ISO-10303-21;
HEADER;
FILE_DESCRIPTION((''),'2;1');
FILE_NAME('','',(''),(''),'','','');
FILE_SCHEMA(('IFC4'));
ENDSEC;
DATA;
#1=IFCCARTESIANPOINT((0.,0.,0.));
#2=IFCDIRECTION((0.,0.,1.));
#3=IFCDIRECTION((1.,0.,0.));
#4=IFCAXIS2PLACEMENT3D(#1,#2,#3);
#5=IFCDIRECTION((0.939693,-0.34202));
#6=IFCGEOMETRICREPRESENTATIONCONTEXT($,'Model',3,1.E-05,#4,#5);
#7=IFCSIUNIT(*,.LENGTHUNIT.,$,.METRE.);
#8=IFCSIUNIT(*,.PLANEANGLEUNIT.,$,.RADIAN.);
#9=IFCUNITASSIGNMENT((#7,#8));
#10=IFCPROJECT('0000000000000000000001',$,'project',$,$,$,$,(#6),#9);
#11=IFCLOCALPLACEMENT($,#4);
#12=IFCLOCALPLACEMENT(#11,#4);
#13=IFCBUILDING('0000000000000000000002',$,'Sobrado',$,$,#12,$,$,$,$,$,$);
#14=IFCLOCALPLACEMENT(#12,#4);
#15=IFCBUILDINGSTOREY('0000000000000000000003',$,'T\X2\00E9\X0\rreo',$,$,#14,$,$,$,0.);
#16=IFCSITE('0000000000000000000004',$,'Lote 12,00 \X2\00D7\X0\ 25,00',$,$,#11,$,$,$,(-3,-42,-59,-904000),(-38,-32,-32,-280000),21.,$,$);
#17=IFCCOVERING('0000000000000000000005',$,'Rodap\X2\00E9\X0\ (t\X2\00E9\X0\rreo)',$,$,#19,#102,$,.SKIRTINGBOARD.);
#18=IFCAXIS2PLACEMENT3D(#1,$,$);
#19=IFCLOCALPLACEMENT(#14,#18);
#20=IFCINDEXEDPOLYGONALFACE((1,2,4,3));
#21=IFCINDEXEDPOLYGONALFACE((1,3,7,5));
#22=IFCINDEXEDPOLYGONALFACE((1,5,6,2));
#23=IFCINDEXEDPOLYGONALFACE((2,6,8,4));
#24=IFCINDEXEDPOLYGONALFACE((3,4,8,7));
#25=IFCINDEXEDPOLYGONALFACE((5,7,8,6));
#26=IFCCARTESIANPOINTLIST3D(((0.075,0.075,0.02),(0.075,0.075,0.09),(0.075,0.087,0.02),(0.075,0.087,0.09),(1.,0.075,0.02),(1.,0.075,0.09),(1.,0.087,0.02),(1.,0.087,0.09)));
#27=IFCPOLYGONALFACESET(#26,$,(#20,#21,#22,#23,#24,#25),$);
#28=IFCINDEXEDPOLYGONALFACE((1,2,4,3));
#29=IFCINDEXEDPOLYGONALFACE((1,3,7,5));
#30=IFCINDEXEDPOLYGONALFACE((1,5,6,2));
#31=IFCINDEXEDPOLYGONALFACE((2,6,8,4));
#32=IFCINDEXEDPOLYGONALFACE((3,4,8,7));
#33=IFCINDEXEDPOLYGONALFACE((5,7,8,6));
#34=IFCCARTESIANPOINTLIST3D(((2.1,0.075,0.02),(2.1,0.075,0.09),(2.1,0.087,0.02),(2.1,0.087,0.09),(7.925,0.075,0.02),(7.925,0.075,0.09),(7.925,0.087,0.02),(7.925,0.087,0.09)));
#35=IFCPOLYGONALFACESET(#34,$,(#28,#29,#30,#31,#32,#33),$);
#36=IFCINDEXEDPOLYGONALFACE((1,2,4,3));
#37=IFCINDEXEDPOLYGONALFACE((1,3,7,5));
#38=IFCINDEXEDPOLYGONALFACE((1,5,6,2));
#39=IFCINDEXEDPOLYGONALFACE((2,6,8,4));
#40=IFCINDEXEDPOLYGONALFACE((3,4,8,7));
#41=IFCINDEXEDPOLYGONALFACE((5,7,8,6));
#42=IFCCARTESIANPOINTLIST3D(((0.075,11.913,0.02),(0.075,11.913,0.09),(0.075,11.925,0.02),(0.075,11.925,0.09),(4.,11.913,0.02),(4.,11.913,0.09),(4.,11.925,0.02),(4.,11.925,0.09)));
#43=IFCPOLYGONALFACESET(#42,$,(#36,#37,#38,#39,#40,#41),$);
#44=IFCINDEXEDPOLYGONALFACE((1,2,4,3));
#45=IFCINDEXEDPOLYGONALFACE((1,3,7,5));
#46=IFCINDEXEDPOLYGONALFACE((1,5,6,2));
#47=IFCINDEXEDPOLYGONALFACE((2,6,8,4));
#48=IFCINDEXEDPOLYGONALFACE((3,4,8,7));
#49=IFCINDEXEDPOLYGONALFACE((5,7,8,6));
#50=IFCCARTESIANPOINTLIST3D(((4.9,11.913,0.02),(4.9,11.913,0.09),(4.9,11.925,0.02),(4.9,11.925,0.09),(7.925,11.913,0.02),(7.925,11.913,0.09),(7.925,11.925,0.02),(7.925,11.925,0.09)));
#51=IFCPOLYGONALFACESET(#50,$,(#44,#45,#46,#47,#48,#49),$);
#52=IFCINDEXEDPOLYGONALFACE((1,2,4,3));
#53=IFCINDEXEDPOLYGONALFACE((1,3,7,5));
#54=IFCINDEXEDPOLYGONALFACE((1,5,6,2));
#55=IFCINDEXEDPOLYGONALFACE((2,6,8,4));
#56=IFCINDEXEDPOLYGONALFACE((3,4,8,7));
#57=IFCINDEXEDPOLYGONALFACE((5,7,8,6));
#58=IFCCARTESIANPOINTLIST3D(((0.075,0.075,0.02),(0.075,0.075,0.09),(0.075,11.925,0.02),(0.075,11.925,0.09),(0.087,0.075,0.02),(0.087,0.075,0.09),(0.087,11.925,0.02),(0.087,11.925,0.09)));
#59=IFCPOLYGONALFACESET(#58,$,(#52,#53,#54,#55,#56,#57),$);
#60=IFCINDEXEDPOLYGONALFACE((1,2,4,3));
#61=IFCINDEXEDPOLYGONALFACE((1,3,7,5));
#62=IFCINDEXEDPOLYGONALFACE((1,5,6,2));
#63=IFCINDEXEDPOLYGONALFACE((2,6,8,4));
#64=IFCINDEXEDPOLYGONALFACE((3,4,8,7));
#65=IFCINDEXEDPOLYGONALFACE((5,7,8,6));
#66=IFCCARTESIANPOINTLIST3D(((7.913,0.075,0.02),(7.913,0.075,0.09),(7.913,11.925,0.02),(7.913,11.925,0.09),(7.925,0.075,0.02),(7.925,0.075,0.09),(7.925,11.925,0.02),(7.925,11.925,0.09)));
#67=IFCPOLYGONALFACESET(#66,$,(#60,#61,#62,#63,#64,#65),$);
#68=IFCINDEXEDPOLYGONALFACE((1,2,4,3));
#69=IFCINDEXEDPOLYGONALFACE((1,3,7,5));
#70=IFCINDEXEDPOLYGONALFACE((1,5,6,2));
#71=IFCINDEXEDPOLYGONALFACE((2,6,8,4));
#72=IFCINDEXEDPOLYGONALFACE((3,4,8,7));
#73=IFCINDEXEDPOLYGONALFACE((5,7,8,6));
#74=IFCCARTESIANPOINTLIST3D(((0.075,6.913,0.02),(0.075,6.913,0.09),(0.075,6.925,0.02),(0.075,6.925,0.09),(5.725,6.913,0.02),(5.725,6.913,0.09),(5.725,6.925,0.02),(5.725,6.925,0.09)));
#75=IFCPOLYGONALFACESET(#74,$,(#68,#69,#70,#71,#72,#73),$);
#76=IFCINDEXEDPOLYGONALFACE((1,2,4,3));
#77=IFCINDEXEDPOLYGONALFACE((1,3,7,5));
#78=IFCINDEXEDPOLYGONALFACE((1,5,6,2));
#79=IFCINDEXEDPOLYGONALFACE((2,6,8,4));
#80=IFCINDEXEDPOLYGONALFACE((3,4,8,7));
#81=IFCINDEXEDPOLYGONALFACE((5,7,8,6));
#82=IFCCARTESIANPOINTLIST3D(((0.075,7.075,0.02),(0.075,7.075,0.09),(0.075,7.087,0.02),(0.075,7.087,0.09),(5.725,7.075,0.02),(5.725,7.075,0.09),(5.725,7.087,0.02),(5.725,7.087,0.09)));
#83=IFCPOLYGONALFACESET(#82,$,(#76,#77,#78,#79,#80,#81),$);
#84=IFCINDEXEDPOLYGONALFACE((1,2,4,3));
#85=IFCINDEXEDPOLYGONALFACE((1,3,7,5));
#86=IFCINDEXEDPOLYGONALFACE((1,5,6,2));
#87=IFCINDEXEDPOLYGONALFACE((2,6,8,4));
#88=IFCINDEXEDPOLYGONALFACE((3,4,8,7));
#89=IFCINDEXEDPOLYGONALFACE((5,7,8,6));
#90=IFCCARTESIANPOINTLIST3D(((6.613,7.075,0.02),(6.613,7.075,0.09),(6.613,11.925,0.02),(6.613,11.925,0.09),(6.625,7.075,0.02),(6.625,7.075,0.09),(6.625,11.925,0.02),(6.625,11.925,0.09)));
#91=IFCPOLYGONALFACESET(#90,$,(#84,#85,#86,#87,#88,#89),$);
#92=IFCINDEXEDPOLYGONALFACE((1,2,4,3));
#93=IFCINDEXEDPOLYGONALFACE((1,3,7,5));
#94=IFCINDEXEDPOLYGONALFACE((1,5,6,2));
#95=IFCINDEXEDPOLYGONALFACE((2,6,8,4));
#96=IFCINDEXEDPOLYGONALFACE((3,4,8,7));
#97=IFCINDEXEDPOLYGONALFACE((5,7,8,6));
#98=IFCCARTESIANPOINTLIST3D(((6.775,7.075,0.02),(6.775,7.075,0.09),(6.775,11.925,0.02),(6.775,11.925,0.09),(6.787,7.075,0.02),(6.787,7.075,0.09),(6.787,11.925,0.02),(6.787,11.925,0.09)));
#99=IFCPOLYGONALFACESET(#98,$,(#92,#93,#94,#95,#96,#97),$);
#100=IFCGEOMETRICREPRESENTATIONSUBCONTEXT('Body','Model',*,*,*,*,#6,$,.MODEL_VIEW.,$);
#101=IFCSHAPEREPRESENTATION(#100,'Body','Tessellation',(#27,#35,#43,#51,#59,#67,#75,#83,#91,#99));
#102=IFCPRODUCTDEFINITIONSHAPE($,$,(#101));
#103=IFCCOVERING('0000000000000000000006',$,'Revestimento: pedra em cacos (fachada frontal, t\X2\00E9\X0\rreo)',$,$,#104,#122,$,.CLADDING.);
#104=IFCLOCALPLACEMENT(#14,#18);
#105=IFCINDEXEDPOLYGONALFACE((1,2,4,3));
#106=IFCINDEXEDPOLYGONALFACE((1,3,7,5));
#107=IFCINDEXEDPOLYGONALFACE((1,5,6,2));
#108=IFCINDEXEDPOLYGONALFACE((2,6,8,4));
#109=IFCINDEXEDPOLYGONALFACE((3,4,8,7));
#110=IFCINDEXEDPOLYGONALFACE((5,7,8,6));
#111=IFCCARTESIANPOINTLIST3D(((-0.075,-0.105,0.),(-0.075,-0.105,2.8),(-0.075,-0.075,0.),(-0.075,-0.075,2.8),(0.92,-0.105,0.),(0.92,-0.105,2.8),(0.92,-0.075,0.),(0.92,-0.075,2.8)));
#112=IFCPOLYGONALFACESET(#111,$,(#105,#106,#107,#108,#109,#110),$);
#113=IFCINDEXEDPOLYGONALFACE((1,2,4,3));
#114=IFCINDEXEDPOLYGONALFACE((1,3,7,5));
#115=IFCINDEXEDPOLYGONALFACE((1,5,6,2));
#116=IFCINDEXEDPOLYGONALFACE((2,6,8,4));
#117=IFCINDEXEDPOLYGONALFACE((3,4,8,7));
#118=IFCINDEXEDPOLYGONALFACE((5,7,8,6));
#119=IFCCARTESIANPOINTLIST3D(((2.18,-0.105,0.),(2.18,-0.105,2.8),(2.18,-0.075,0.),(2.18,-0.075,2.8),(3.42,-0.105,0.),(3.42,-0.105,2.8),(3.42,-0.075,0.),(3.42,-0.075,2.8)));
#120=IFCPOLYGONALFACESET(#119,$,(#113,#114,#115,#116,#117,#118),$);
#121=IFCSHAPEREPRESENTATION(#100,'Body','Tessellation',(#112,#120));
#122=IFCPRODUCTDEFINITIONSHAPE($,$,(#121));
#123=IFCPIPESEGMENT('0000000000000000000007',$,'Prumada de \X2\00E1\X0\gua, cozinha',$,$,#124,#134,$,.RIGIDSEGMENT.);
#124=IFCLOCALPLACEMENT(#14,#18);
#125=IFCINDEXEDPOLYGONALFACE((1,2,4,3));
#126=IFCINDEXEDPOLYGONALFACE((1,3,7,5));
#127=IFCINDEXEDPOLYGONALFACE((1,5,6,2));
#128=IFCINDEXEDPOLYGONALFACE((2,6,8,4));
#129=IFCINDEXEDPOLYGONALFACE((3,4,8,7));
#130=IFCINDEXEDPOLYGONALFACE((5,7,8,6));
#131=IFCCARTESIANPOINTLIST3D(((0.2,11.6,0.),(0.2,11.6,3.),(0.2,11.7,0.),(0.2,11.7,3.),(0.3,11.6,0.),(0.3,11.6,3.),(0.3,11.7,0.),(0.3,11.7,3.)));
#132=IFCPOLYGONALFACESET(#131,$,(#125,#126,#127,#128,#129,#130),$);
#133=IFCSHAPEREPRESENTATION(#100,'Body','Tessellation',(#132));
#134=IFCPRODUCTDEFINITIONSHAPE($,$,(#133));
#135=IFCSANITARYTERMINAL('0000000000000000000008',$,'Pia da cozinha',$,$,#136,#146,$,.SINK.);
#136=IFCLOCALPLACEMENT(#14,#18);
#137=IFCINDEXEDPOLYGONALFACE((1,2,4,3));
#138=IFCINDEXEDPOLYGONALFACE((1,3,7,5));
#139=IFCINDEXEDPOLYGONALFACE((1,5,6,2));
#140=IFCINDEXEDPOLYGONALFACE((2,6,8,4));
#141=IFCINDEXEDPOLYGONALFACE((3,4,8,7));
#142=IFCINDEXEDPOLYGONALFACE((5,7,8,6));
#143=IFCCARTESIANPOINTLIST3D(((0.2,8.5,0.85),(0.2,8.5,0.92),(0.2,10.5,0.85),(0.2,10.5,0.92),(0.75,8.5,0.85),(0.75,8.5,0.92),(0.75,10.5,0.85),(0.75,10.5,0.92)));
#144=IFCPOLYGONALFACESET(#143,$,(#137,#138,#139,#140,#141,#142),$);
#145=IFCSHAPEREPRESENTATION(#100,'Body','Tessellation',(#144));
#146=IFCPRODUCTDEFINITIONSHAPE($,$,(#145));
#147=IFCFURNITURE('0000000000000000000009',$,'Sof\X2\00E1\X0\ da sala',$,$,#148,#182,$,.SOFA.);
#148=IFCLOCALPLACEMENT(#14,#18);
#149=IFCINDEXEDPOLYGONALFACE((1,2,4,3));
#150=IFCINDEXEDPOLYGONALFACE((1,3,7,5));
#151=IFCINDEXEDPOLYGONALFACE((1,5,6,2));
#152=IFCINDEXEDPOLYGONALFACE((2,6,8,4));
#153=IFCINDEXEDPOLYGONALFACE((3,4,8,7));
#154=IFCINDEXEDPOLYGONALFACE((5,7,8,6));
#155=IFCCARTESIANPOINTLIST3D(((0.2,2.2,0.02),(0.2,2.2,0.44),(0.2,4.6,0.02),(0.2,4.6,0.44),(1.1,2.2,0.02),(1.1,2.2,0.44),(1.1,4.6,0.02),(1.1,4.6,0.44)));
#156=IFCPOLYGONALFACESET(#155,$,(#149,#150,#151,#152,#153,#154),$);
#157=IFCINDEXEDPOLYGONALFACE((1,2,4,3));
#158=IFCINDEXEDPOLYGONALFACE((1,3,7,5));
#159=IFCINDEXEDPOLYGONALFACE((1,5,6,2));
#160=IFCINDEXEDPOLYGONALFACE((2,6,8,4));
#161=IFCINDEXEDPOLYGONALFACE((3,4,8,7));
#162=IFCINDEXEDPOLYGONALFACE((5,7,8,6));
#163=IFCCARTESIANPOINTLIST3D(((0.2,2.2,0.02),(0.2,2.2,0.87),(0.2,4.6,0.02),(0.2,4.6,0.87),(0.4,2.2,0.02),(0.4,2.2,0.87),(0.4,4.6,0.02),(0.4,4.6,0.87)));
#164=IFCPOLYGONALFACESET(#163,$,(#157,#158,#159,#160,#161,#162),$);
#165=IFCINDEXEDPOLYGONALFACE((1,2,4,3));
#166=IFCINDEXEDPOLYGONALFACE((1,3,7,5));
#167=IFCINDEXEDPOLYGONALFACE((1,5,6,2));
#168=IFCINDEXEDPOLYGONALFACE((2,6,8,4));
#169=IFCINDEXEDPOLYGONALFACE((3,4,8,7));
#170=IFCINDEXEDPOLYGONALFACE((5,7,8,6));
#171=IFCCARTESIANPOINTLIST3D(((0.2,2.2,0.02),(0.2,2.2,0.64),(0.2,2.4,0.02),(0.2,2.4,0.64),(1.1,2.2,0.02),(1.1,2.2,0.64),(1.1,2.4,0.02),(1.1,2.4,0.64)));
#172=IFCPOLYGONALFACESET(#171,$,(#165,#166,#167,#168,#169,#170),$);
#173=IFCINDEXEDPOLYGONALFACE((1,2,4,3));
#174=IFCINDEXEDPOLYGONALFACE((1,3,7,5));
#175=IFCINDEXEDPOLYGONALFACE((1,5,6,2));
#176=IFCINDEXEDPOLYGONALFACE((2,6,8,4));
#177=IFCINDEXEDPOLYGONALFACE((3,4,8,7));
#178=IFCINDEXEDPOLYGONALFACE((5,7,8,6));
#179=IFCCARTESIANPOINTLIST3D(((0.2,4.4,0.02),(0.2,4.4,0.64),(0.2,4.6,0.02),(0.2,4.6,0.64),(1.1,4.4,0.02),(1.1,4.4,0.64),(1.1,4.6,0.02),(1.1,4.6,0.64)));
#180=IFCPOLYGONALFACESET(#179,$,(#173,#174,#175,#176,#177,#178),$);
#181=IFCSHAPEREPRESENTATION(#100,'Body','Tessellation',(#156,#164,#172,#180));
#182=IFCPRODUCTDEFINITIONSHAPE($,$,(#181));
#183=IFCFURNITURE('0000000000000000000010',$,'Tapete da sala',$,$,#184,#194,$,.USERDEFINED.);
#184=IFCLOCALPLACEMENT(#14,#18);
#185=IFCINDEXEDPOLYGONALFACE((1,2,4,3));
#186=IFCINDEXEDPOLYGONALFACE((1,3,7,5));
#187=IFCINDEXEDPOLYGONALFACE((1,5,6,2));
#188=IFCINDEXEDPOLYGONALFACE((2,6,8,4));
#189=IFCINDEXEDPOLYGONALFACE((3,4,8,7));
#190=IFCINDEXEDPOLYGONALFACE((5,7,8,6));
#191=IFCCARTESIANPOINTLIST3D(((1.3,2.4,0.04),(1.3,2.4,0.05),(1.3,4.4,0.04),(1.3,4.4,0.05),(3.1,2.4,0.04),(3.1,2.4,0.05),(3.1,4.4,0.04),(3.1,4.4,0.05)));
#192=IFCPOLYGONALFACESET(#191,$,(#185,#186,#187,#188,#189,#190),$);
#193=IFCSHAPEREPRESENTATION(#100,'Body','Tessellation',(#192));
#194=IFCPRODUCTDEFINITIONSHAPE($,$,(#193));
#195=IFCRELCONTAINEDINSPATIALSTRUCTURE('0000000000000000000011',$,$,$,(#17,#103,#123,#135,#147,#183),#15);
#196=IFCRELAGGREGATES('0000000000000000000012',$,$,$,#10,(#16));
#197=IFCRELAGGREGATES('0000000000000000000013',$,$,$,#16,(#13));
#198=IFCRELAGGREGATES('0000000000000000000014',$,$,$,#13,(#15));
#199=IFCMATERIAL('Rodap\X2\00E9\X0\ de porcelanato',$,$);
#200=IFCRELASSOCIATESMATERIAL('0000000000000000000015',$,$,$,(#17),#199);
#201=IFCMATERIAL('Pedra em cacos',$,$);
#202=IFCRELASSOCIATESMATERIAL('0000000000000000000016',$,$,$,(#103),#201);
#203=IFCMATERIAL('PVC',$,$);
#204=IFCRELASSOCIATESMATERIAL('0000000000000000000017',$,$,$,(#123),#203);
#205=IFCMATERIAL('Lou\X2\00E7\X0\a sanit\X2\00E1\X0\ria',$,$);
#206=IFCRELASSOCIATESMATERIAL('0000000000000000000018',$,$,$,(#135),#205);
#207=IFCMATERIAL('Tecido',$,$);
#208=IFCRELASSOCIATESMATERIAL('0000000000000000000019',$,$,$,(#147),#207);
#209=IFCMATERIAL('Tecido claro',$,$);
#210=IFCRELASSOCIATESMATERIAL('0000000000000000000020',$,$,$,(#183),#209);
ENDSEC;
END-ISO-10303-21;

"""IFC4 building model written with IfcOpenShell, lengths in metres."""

from ifc_helpers import new_model, si_unit, direction, frame, origin_with_axes, place, context, subcontext, project, spatial, line, indexed_curve, outline, extrude, material, element, save


model = new_model("IFC4")

# Units and contexts
model_context = context("Model", 3, precision=1e-05, world=origin_with_axes(), true_north=direction((0.939693, -0.34202)))
body_context = subcontext(model_context, "Body", "Model", "MODEL_VIEW")
ifc_project = project(units=[si_unit("LENGTHUNIT", "METRE"), si_unit("PLANEANGLEUNIT", "RADIAN")], contexts=[model_context])

# Site, building, storey
site_placement = place(None, origin_with_axes())
site = spatial("IfcSite", under=ifc_project, at=site_placement, Name="Lote 12,00 × 25,00", RefLatitude=(-3, -42, -59, -904000), RefLongitude=(-38, -32, -32, -280000), RefElevation=21.0)
building_placement = place(site_placement, origin_with_axes())
building = spatial("IfcBuilding", under=site, at=building_placement, Name="Sobrado")
storey_placement = place(building_placement, origin_with_axes())
storey = spatial("IfcBuildingStorey", under=building, at=storey_placement, Name="Térreo", Elevation=0.0)

# Coverings
ifc_material_1 = material(Name="Rodapé de porcelanato")
covering_1_placement = place(storey_placement, origin_with_axes())
element("IfcCovering", 1, at=covering_1_placement, inside=storey, material=ifc_material_1, Name="Rodapé (térreo)", PredefinedType="SKIRTINGBOARD", context=body_context, shape_type="SweptSolid", body=[
    extrude(outline(indexed_curve([(0.075, 0.075), (1.0, 0.075), (1.0, 0.087), (0.075, 0.087)], segments=[line(1, 2, 3, 4, 1)])), frame((0.0, 0.0, 0.02), z_axis=(0.0, 0.0, 1.0), x_axis=(1.0, 0.0, 0.0)), (0.0, 0.0, 1.0), 0.07),
    extrude(outline(indexed_curve([(2.1, 0.075), (7.925, 0.075), (7.925, 0.087), (2.1, 0.087)], segments=[line(1, 2, 3, 4, 1)])), frame((0.0, 0.0, 0.02), z_axis=(0.0, 0.0, 1.0), x_axis=(1.0, 0.0, 0.0)), (0.0, 0.0, 1.0), 0.07),
    extrude(outline(indexed_curve([(0.075, 11.913), (4.0, 11.913), (4.0, 11.925), (0.075, 11.925)], segments=[line(1, 2, 3, 4, 1)])), frame((0.0, 0.0, 0.02), z_axis=(0.0, 0.0, 1.0), x_axis=(1.0, 0.0, 0.0)), (0.0, 0.0, 1.0), 0.07),
    extrude(outline(indexed_curve([(4.9, 11.913), (7.925, 11.913), (7.925, 11.925), (4.9, 11.925)], segments=[line(1, 2, 3, 4, 1)])), frame((0.0, 0.0, 0.02), z_axis=(0.0, 0.0, 1.0), x_axis=(1.0, 0.0, 0.0)), (0.0, 0.0, 1.0), 0.07),
    extrude(outline(indexed_curve([(0.075, 0.075), (0.087, 0.075), (0.087, 11.925), (0.075, 11.925)], segments=[line(1, 2, 3, 4, 1)])), frame((0.0, 0.0, 0.02), z_axis=(0.0, 0.0, 1.0), x_axis=(1.0, 0.0, 0.0)), (0.0, 0.0, 1.0), 0.07),
    extrude(outline(indexed_curve([(7.913, 0.075), (7.925, 0.075), (7.925, 11.925), (7.913, 11.925)], segments=[line(1, 2, 3, 4, 1)])), frame((0.0, 0.0, 0.02), z_axis=(0.0, 0.0, 1.0), x_axis=(1.0, 0.0, 0.0)), (0.0, 0.0, 1.0), 0.07),
    extrude(outline(indexed_curve([(0.075, 6.913), (5.725, 6.913), (5.725, 6.925), (0.075, 6.925)], segments=[line(1, 2, 3, 4, 1)])), frame((0.0, 0.0, 0.02), z_axis=(0.0, 0.0, 1.0), x_axis=(1.0, 0.0, 0.0)), (0.0, 0.0, 1.0), 0.07),
    extrude(outline(indexed_curve([(0.075, 7.075), (5.725, 7.075), (5.725, 7.087), (0.075, 7.087)], segments=[line(1, 2, 3, 4, 1)])), frame((0.0, 0.0, 0.02), z_axis=(0.0, 0.0, 1.0), x_axis=(1.0, 0.0, 0.0)), (0.0, 0.0, 1.0), 0.07),
    extrude(outline(indexed_curve([(6.613, 7.075), (6.625, 7.075), (6.625, 11.925), (6.613, 11.925)], segments=[line(1, 2, 3, 4, 1)])), frame((0.0, 0.0, 0.02), z_axis=(0.0, 0.0, 1.0), x_axis=(1.0, 0.0, 0.0)), (0.0, 0.0, 1.0), 0.07),
    extrude(outline(indexed_curve([(6.775, 7.075), (6.787, 7.075), (6.787, 11.925), (6.775, 11.925)], segments=[line(1, 2, 3, 4, 1)])), frame((0.0, 0.0, 0.02), z_axis=(0.0, 0.0, 1.0), x_axis=(1.0, 0.0, 0.0)), (0.0, 0.0, 1.0), 0.07),
])
ifc_material_2 = material(Name="Pedra em cacos")
covering_2_placement = place(storey_placement, origin_with_axes())
element("IfcCovering", 2, at=covering_2_placement, inside=storey, material=ifc_material_2, Name="Revestimento: pedra em cacos (fachada frontal, térreo)", PredefinedType="CLADDING", context=body_context, shape_type="SweptSolid", body=[
    extrude(outline(indexed_curve([(-0.075, -0.105), (0.92, -0.105), (0.92, -0.075), (-0.075, -0.075)], segments=[line(1, 2, 3, 4, 1)])), origin_with_axes(), (0.0, 0.0, 1.0), 2.8),
    extrude(outline(indexed_curve([(2.18, -0.105), (3.42, -0.105), (3.42, -0.075), (2.18, -0.075)], segments=[line(1, 2, 3, 4, 1)])), origin_with_axes(), (0.0, 0.0, 1.0), 2.8),
])

# Pipe segment
ifc_material_3 = material(Name="PVC")
pipe_segment_placement = place(storey_placement, origin_with_axes())
element("IfcPipeSegment", 3, at=pipe_segment_placement, inside=storey, material=ifc_material_3, Name="Prumada de água, cozinha", PredefinedType="RIGIDSEGMENT", context=body_context, shape_type="SweptSolid", body=[
    extrude(outline(indexed_curve([(0.2, 11.6), (0.3, 11.6), (0.3, 11.7), (0.2, 11.7)], segments=[line(1, 2, 3, 4, 1)])), origin_with_axes(), (0.0, 0.0, 1.0), 3.0),
])

# Sanitary terminal
ifc_material_4 = material(Name="Louça sanitária")
sanitary_terminal_placement = place(storey_placement, origin_with_axes())
element("IfcSanitaryTerminal", 4, at=sanitary_terminal_placement, inside=storey, material=ifc_material_4, Name="Pia da cozinha", PredefinedType="SINK", context=body_context, shape_type="SweptSolid", body=[
    extrude(outline(indexed_curve([(0.2, 8.5), (0.75, 8.5), (0.75, 10.5), (0.2, 10.5)], segments=[line(1, 2, 3, 4, 1)])), frame((0.0, 0.0, 0.85), z_axis=(0.0, 0.0, 1.0), x_axis=(1.0, 0.0, 0.0)), (0.0, 0.0, 1.0), 0.07),
])

# Furniture
ifc_material_5 = material(Name="Tecido")
furniture_1_placement = place(storey_placement, origin_with_axes())
element("IfcFurniture", 5, at=furniture_1_placement, inside=storey, material=ifc_material_5, Name="Sofá da sala", PredefinedType="SOFA", context=body_context, shape_type="SweptSolid", body=[
    extrude(outline(indexed_curve([(0.2, 2.2), (1.1, 2.2), (1.1, 4.6), (0.2, 4.6)], segments=[line(1, 2, 3, 4, 1)])), frame((0.0, 0.0, 0.02), z_axis=(0.0, 0.0, 1.0), x_axis=(1.0, 0.0, 0.0)), (0.0, 0.0, 1.0), 0.42),
    extrude(outline(indexed_curve([(0.2, 2.2), (0.4, 2.2), (0.4, 4.6), (0.2, 4.6)], segments=[line(1, 2, 3, 4, 1)])), frame((0.0, 0.0, 0.02), z_axis=(0.0, 0.0, 1.0), x_axis=(1.0, 0.0, 0.0)), (0.0, 0.0, 1.0), 0.85),
    extrude(outline(indexed_curve([(0.2, 2.2), (1.1, 2.2), (1.1, 2.4), (0.2, 2.4)], segments=[line(1, 2, 3, 4, 1)])), frame((0.0, 0.0, 0.02), z_axis=(0.0, 0.0, 1.0), x_axis=(1.0, 0.0, 0.0)), (0.0, 0.0, 1.0), 0.62),
    extrude(outline(indexed_curve([(0.2, 4.4), (1.1, 4.4), (1.1, 4.6), (0.2, 4.6)], segments=[line(1, 2, 3, 4, 1)])), frame((0.0, 0.0, 0.02), z_axis=(0.0, 0.0, 1.0), x_axis=(1.0, 0.0, 0.0)), (0.0, 0.0, 1.0), 0.62),
])
ifc_material_6 = material(Name="Tecido claro")
furniture_2_placement = place(storey_placement, origin_with_axes())
element("IfcFurniture", 6, at=furniture_2_placement, inside=storey, material=ifc_material_6, Name="Tapete da sala", PredefinedType="USERDEFINED", context=body_context, shape_type="SweptSolid", body=[
    extrude(outline(indexed_curve([(1.3, 2.4), (3.1, 2.4), (3.1, 4.4), (1.3, 4.4)], segments=[line(1, 2, 3, 4, 1)])), frame((0.0, 0.0, 0.04), z_axis=(0.0, 0.0, 1.0), x_axis=(1.0, 0.0, 0.0)), (0.0, 0.0, 1.0), 0.01),
])

save(model, "model.ifc")
